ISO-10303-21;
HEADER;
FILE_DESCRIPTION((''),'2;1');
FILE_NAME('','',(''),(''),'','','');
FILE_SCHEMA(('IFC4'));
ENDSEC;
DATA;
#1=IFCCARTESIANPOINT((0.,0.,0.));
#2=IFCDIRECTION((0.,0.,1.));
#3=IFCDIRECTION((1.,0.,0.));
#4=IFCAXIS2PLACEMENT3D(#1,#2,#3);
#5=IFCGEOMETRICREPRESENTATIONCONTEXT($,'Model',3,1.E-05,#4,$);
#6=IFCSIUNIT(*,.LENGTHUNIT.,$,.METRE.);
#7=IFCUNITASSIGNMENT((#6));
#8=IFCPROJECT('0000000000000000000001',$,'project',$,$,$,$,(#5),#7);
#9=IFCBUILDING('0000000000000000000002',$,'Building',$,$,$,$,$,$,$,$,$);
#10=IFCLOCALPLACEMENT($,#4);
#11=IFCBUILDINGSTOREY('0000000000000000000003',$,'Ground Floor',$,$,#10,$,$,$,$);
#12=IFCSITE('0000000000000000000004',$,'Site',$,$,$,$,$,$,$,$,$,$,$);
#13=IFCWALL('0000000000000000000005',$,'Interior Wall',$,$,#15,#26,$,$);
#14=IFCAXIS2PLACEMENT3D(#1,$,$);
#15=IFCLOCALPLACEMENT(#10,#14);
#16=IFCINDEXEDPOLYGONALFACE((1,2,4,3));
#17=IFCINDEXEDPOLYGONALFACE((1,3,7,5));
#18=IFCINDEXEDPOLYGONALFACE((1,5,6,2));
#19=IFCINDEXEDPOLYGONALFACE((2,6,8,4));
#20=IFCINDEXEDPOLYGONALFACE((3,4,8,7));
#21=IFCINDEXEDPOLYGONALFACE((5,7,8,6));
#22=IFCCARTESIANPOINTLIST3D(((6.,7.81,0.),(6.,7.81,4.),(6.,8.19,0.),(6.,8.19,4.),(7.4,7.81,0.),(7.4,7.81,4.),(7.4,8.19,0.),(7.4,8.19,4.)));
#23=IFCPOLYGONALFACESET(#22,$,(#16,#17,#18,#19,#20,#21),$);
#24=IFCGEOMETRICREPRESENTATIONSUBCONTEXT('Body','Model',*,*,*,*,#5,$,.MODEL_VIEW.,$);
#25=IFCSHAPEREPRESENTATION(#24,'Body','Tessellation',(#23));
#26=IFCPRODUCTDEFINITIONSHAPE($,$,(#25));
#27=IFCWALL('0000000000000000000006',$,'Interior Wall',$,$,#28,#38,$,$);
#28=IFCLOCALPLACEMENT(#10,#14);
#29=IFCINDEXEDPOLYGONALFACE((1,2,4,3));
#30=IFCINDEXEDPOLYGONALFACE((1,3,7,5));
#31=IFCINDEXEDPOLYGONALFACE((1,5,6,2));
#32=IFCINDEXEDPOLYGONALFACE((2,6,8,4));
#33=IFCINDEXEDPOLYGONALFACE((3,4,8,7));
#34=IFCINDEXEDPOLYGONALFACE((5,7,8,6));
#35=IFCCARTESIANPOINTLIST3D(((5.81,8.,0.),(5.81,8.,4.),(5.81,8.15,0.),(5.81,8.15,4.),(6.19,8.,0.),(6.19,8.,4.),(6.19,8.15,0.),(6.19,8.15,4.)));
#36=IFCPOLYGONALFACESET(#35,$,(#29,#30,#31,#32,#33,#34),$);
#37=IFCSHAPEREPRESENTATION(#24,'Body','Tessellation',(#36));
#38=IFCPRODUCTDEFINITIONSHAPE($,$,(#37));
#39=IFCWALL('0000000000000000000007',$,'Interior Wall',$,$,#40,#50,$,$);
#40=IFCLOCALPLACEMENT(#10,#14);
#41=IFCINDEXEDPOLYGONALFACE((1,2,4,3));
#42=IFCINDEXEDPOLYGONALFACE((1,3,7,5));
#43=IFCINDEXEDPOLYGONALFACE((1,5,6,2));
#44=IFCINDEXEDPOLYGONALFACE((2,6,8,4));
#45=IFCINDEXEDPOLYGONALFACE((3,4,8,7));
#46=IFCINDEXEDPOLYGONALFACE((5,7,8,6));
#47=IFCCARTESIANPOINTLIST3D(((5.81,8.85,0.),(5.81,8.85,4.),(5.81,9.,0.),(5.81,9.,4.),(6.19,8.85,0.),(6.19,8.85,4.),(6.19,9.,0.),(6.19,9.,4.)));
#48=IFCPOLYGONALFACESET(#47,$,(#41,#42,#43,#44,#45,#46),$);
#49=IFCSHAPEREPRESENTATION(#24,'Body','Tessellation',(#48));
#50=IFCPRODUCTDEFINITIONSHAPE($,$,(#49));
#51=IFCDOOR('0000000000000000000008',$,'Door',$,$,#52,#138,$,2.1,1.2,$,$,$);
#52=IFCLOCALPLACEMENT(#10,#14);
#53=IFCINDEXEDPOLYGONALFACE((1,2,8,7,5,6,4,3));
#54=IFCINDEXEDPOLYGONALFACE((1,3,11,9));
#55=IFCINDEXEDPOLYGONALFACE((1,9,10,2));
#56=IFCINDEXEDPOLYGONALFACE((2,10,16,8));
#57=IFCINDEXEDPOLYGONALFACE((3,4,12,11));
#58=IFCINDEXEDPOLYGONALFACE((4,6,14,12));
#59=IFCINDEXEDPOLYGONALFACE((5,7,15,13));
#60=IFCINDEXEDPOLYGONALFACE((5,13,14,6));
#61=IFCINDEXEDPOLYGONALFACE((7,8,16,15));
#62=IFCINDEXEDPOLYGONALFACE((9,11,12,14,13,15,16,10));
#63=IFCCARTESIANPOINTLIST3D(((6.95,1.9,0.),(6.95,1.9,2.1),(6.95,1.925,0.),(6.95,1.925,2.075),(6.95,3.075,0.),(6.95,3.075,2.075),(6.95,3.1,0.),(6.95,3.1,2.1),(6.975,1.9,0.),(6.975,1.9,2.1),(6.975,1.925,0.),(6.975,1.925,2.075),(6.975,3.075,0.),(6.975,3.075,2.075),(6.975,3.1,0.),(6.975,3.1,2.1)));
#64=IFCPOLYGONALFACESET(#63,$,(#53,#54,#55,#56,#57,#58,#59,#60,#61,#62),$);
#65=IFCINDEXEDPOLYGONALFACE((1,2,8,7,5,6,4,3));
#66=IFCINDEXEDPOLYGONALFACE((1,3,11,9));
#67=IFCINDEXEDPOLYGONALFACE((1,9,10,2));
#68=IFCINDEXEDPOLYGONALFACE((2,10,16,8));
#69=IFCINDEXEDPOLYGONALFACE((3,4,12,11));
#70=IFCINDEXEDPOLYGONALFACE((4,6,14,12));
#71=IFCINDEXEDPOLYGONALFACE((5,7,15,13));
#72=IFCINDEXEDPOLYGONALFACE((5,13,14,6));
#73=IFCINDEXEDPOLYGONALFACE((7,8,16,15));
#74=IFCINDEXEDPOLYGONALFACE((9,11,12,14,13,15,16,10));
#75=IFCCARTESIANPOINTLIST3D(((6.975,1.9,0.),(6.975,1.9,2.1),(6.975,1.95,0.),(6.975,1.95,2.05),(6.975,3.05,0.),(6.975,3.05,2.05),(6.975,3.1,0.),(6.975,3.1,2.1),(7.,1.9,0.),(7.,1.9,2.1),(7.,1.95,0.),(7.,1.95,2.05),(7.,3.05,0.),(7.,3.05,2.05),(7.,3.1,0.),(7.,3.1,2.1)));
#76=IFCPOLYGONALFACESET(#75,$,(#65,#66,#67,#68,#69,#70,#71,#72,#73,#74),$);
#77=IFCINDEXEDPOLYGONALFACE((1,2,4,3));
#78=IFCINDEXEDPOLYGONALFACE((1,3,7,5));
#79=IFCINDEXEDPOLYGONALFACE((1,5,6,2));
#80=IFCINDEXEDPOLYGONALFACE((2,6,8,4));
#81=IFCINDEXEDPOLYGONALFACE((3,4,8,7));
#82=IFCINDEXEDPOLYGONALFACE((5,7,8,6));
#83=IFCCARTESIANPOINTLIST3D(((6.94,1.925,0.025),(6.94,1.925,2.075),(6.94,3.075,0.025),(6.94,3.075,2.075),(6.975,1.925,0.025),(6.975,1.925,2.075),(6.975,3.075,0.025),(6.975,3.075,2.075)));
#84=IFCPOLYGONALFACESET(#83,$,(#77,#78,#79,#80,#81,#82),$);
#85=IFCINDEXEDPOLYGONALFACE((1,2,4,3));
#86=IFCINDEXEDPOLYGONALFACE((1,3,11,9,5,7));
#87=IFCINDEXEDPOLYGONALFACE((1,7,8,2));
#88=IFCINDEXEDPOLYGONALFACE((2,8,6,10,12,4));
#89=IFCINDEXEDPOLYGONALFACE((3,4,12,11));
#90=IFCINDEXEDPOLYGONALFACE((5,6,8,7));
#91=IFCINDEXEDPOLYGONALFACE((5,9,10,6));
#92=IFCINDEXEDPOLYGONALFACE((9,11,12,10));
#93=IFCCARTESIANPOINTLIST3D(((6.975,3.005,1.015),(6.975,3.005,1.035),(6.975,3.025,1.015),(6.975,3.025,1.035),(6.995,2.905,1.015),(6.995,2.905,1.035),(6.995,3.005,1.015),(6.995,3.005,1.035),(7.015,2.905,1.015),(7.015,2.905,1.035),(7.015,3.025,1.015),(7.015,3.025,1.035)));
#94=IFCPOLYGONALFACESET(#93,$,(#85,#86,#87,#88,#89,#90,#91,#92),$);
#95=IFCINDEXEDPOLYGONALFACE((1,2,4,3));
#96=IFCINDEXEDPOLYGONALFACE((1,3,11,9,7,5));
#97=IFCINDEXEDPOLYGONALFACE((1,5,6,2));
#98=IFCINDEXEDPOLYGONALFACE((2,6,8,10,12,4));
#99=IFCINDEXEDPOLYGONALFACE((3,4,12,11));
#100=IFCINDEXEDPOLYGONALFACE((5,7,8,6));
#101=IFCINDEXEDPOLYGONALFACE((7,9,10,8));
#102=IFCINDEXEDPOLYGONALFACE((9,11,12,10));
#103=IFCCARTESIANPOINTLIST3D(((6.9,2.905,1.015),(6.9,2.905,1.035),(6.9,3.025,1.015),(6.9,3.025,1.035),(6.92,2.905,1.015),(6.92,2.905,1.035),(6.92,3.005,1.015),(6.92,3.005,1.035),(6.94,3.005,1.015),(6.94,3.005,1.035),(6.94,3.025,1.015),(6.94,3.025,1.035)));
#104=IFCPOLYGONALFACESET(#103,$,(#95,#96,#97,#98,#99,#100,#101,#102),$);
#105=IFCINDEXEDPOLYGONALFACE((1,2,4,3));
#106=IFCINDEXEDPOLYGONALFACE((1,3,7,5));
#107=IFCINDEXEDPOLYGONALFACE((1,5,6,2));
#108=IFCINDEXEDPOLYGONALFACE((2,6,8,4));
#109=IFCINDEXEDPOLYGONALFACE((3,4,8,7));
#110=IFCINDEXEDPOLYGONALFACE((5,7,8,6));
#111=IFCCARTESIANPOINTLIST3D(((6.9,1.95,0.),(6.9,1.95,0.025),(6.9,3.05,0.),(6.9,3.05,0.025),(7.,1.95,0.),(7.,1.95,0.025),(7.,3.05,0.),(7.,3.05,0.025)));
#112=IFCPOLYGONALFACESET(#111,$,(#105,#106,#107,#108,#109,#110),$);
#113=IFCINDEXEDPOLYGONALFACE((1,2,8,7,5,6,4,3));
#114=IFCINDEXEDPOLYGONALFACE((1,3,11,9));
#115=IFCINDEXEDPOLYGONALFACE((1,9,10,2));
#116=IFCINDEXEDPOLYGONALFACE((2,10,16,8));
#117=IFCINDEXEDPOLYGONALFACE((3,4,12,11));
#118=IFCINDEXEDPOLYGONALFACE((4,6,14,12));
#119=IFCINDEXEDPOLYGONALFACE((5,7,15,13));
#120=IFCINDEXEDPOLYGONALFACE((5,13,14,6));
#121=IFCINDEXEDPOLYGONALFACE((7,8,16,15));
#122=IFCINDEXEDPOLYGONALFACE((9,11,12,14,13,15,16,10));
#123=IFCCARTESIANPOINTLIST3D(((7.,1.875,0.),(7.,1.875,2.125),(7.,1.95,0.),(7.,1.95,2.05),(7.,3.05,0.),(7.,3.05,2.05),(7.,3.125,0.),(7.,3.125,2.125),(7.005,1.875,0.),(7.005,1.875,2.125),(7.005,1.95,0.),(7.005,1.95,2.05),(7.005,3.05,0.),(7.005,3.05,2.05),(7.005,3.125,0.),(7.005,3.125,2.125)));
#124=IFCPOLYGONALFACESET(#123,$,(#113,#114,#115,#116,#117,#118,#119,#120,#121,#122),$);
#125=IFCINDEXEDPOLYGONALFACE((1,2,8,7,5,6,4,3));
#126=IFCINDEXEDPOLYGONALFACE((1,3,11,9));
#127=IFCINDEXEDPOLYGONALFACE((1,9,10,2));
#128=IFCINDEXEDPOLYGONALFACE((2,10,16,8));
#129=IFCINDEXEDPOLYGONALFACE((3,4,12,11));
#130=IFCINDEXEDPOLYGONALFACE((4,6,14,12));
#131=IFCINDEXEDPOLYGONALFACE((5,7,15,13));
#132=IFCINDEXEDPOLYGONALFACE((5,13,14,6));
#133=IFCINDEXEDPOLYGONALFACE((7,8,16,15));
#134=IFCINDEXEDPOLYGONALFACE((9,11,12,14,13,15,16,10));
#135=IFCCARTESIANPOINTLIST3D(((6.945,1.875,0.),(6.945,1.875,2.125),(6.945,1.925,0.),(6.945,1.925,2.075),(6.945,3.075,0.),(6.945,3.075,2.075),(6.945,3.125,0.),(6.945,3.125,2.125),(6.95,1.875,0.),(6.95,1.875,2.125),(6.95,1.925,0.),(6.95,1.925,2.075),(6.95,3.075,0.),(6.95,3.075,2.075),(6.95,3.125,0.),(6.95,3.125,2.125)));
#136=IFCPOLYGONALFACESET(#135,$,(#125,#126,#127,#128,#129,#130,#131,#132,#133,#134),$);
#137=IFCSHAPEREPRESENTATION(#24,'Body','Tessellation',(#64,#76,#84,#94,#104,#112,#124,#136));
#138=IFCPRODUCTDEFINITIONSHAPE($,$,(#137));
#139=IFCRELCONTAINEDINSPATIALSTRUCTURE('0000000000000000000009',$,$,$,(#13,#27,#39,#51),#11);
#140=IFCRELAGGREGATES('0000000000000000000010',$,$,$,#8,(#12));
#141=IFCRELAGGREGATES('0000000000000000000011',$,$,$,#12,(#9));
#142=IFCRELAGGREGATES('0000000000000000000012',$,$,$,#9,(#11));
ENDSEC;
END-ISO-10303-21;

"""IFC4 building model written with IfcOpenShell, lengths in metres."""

from ifc_helpers import new_model, si_unit, frame, origin_with_axes, place, context, subcontext, project, spatial, line, indexed_curve, outline, extrude, element, save


model = new_model("IFC4")

# Units and contexts
model_context = context("Model", 3, precision=1e-05, world=origin_with_axes())
body_context = subcontext(model_context, "Body", "Model", "MODEL_VIEW")
ifc_project = project(units=[si_unit("LENGTHUNIT", "METRE")], contexts=[model_context])

# Site, building, storey
site = spatial("IfcSite", under=ifc_project, Name="Site")
building = spatial("IfcBuilding", under=site, Name="Building")
storey_placement = place(None, origin_with_axes())
storey = spatial("IfcBuildingStorey", under=building, at=storey_placement, Name="Ground Floor")

# Walls
for number, where, z_axis, x_axis, name in (
    (1, (7.4, 8.0, 0.0), (0.0, 0.0, 1.0), (-1.0, 0.0, 0.0), "Interior Wall"),
):
    element("IfcWall", number, at=place(storey_placement, frame(where, z_axis=z_axis, x_axis=x_axis)), inside=storey, Name=name, context=body_context, shape_type="SweptSolid", body=[
        extrude(outline(indexed_curve([(0.0, 0.0), (0.0, 0.38), (1.4, 0.38), (1.4, 0.0), (0.0, 0.0)], self_intersect=False)), frame((0.0, -0.19, 0.0), z_axis=(0.0, 0.0, 1.0), x_axis=(1.0, 0.0, 0.0)), (0.0, 0.0, 1.0), 4.0),
    ])
for number, where, z_axis, x_axis, name in (
    (2, (6.0, 8.0, 0.0), (0.0, 0.0, 1.0), (0.0, 1.0, 0.0), "Interior Wall"),
    (3, (6.0, 8.85, 0.0), (0.0, 0.0, 1.0), (0.0, 1.0, 0.0), "Interior Wall"),
):
    element("IfcWall", number, at=place(storey_placement, frame(where, z_axis=z_axis, x_axis=x_axis)), inside=storey, Name=name, context=body_context, shape_type="SweptSolid", body=[
        extrude(outline(indexed_curve([(0.0, 0.0), (0.0, 0.38), (0.15, 0.38), (0.15, 0.0), (0.0, 0.0)], self_intersect=False)), frame((0.0, -0.19, 0.0), z_axis=(0.0, 0.0, 1.0), x_axis=(1.0, 0.0, 0.0)), (0.0, 0.0, 1.0), 4.0),
    ])

# Door
door_1_placement = place(storey_placement, frame((7.0, 1.9, 0.0), z_axis=(0.0, 0.0, 1.0), x_axis=(0.0, 1.0, 0.0)))
element("IfcDoor", 4, at=door_1_placement, inside=storey, Name="Door", OverallHeight=2.1, OverallWidth=1.2, context=body_context, shape_type="SweptSolid", body=[
    extrude(outline(indexed_curve([(0.0, 0.0), (0.0, 2.1), (1.2, 2.1), (1.2, 0.0), (1.175, 0.0), (1.175, 2.075), (0.025, 2.075), (0.025, 0.0)], segments=[line(1, 2, 3, 4, 5, 6, 7, 8, 1)])), frame((0.0, 0.025, 0.0), z_axis=(0.0, -1.0, 0.0), x_axis=(1.0, 0.0, 0.0)), (0.0, 0.0, -1.0), 0.025),
    extrude(outline(indexed_curve([(0.0, 0.0), (0.0, 2.1), (1.2, 2.1), (1.2, 0.0), (1.15, 0.0), (1.15, 2.05), (0.05, 2.05), (0.05, 0.0)], segments=[line(1, 2, 3, 4, 5, 6, 7, 8, 1)])), frame((0.0, 0.0, 0.0), z_axis=(0.0, -1.0, 0.0), x_axis=(1.0, 0.0, 0.0)), (0.0, 0.0, -1.0), 0.025),
    extrude(outline(indexed_curve([(0.0, 0.0), (1.15, 0.0), (1.15, 0.035), (0.0, 0.035)], segments=[line(1, 2, 3, 4, 1)])), frame((0.025, 0.025, 0.025), z_axis=(0.0, 0.0, 1.0), x_axis=(1.0, 0.0, 0.0)), (0.0, 0.0, 1.0), 2.05),
    extrude(outline(indexed_curve([(0.0, 0.0), (0.0, -0.04), (-0.12, -0.04), (-0.12, -0.02), (-0.02, -0.02), (-0.02, 0.0)], segments=[line(1, 2, 3, 4, 5, 6, 1)])), frame((1.125, 0.025, 1.015), z_axis=(0.0, 0.0, 1.0), x_axis=(1.0, 0.0, 0.0)), (0.0, 0.0, 1.0), 0.02),
    extrude(outline(indexed_curve([(0.0, 0.0), (0.0, 0.04), (-0.12, 0.04), (-0.12, 0.02), (-0.02, 0.02), (-0.02, 0.0)], segments=[line(1, 2, 3, 4, 5, 6, 1)])), frame((1.125, 0.06, 1.015), z_axis=(0.0, 0.0, 1.0), x_axis=(1.0, 0.0, 0.0)), (0.0, 0.0, 1.0), 0.02),
    extrude(outline(indexed_curve([(0.0, 0.0), (1.1, 0.0), (1.1, 0.1), (0.0, 0.1)], segments=[line(1, 2, 3, 4, 1)])), frame((0.05, 0.0, 0.0), z_axis=(0.0, 0.0, 1.0), x_axis=(1.0, 0.0, 0.0)), (0.0, 0.0, 1.0), 0.025),
    extrude(outline(indexed_curve([(0.0, 0.0), (0.0, 2.125), (1.25, 2.125), (1.25, 0.0), (1.175, 0.0), (1.175, 2.05), (0.075, 2.05), (0.075, 0.0)], segments=[line(1, 2, 3, 4, 5, 6, 7, 8, 1)])), frame((-0.025, -0.005, 0.0), z_axis=(0.0, -1.0, 0.0), x_axis=(1.0, 0.0, 0.0)), (0.0, 0.0, -1.0), 0.005),
    extrude(outline(indexed_curve([(0.0, 0.0), (0.0, 2.125), (1.25, 2.125), (1.25, 0.0), (1.2, 0.0), (1.2, 2.075), (0.05, 2.075), (0.05, 0.0)], segments=[line(1, 2, 3, 4, 5, 6, 7, 8, 1)])), frame((-0.025, 0.05, 0.0), z_axis=(0.0, -1.0, 0.0), x_axis=(1.0, 0.0, 0.0)), (0.0, 0.0, -1.0), 0.005),
])

save(model, "model.ifc")
